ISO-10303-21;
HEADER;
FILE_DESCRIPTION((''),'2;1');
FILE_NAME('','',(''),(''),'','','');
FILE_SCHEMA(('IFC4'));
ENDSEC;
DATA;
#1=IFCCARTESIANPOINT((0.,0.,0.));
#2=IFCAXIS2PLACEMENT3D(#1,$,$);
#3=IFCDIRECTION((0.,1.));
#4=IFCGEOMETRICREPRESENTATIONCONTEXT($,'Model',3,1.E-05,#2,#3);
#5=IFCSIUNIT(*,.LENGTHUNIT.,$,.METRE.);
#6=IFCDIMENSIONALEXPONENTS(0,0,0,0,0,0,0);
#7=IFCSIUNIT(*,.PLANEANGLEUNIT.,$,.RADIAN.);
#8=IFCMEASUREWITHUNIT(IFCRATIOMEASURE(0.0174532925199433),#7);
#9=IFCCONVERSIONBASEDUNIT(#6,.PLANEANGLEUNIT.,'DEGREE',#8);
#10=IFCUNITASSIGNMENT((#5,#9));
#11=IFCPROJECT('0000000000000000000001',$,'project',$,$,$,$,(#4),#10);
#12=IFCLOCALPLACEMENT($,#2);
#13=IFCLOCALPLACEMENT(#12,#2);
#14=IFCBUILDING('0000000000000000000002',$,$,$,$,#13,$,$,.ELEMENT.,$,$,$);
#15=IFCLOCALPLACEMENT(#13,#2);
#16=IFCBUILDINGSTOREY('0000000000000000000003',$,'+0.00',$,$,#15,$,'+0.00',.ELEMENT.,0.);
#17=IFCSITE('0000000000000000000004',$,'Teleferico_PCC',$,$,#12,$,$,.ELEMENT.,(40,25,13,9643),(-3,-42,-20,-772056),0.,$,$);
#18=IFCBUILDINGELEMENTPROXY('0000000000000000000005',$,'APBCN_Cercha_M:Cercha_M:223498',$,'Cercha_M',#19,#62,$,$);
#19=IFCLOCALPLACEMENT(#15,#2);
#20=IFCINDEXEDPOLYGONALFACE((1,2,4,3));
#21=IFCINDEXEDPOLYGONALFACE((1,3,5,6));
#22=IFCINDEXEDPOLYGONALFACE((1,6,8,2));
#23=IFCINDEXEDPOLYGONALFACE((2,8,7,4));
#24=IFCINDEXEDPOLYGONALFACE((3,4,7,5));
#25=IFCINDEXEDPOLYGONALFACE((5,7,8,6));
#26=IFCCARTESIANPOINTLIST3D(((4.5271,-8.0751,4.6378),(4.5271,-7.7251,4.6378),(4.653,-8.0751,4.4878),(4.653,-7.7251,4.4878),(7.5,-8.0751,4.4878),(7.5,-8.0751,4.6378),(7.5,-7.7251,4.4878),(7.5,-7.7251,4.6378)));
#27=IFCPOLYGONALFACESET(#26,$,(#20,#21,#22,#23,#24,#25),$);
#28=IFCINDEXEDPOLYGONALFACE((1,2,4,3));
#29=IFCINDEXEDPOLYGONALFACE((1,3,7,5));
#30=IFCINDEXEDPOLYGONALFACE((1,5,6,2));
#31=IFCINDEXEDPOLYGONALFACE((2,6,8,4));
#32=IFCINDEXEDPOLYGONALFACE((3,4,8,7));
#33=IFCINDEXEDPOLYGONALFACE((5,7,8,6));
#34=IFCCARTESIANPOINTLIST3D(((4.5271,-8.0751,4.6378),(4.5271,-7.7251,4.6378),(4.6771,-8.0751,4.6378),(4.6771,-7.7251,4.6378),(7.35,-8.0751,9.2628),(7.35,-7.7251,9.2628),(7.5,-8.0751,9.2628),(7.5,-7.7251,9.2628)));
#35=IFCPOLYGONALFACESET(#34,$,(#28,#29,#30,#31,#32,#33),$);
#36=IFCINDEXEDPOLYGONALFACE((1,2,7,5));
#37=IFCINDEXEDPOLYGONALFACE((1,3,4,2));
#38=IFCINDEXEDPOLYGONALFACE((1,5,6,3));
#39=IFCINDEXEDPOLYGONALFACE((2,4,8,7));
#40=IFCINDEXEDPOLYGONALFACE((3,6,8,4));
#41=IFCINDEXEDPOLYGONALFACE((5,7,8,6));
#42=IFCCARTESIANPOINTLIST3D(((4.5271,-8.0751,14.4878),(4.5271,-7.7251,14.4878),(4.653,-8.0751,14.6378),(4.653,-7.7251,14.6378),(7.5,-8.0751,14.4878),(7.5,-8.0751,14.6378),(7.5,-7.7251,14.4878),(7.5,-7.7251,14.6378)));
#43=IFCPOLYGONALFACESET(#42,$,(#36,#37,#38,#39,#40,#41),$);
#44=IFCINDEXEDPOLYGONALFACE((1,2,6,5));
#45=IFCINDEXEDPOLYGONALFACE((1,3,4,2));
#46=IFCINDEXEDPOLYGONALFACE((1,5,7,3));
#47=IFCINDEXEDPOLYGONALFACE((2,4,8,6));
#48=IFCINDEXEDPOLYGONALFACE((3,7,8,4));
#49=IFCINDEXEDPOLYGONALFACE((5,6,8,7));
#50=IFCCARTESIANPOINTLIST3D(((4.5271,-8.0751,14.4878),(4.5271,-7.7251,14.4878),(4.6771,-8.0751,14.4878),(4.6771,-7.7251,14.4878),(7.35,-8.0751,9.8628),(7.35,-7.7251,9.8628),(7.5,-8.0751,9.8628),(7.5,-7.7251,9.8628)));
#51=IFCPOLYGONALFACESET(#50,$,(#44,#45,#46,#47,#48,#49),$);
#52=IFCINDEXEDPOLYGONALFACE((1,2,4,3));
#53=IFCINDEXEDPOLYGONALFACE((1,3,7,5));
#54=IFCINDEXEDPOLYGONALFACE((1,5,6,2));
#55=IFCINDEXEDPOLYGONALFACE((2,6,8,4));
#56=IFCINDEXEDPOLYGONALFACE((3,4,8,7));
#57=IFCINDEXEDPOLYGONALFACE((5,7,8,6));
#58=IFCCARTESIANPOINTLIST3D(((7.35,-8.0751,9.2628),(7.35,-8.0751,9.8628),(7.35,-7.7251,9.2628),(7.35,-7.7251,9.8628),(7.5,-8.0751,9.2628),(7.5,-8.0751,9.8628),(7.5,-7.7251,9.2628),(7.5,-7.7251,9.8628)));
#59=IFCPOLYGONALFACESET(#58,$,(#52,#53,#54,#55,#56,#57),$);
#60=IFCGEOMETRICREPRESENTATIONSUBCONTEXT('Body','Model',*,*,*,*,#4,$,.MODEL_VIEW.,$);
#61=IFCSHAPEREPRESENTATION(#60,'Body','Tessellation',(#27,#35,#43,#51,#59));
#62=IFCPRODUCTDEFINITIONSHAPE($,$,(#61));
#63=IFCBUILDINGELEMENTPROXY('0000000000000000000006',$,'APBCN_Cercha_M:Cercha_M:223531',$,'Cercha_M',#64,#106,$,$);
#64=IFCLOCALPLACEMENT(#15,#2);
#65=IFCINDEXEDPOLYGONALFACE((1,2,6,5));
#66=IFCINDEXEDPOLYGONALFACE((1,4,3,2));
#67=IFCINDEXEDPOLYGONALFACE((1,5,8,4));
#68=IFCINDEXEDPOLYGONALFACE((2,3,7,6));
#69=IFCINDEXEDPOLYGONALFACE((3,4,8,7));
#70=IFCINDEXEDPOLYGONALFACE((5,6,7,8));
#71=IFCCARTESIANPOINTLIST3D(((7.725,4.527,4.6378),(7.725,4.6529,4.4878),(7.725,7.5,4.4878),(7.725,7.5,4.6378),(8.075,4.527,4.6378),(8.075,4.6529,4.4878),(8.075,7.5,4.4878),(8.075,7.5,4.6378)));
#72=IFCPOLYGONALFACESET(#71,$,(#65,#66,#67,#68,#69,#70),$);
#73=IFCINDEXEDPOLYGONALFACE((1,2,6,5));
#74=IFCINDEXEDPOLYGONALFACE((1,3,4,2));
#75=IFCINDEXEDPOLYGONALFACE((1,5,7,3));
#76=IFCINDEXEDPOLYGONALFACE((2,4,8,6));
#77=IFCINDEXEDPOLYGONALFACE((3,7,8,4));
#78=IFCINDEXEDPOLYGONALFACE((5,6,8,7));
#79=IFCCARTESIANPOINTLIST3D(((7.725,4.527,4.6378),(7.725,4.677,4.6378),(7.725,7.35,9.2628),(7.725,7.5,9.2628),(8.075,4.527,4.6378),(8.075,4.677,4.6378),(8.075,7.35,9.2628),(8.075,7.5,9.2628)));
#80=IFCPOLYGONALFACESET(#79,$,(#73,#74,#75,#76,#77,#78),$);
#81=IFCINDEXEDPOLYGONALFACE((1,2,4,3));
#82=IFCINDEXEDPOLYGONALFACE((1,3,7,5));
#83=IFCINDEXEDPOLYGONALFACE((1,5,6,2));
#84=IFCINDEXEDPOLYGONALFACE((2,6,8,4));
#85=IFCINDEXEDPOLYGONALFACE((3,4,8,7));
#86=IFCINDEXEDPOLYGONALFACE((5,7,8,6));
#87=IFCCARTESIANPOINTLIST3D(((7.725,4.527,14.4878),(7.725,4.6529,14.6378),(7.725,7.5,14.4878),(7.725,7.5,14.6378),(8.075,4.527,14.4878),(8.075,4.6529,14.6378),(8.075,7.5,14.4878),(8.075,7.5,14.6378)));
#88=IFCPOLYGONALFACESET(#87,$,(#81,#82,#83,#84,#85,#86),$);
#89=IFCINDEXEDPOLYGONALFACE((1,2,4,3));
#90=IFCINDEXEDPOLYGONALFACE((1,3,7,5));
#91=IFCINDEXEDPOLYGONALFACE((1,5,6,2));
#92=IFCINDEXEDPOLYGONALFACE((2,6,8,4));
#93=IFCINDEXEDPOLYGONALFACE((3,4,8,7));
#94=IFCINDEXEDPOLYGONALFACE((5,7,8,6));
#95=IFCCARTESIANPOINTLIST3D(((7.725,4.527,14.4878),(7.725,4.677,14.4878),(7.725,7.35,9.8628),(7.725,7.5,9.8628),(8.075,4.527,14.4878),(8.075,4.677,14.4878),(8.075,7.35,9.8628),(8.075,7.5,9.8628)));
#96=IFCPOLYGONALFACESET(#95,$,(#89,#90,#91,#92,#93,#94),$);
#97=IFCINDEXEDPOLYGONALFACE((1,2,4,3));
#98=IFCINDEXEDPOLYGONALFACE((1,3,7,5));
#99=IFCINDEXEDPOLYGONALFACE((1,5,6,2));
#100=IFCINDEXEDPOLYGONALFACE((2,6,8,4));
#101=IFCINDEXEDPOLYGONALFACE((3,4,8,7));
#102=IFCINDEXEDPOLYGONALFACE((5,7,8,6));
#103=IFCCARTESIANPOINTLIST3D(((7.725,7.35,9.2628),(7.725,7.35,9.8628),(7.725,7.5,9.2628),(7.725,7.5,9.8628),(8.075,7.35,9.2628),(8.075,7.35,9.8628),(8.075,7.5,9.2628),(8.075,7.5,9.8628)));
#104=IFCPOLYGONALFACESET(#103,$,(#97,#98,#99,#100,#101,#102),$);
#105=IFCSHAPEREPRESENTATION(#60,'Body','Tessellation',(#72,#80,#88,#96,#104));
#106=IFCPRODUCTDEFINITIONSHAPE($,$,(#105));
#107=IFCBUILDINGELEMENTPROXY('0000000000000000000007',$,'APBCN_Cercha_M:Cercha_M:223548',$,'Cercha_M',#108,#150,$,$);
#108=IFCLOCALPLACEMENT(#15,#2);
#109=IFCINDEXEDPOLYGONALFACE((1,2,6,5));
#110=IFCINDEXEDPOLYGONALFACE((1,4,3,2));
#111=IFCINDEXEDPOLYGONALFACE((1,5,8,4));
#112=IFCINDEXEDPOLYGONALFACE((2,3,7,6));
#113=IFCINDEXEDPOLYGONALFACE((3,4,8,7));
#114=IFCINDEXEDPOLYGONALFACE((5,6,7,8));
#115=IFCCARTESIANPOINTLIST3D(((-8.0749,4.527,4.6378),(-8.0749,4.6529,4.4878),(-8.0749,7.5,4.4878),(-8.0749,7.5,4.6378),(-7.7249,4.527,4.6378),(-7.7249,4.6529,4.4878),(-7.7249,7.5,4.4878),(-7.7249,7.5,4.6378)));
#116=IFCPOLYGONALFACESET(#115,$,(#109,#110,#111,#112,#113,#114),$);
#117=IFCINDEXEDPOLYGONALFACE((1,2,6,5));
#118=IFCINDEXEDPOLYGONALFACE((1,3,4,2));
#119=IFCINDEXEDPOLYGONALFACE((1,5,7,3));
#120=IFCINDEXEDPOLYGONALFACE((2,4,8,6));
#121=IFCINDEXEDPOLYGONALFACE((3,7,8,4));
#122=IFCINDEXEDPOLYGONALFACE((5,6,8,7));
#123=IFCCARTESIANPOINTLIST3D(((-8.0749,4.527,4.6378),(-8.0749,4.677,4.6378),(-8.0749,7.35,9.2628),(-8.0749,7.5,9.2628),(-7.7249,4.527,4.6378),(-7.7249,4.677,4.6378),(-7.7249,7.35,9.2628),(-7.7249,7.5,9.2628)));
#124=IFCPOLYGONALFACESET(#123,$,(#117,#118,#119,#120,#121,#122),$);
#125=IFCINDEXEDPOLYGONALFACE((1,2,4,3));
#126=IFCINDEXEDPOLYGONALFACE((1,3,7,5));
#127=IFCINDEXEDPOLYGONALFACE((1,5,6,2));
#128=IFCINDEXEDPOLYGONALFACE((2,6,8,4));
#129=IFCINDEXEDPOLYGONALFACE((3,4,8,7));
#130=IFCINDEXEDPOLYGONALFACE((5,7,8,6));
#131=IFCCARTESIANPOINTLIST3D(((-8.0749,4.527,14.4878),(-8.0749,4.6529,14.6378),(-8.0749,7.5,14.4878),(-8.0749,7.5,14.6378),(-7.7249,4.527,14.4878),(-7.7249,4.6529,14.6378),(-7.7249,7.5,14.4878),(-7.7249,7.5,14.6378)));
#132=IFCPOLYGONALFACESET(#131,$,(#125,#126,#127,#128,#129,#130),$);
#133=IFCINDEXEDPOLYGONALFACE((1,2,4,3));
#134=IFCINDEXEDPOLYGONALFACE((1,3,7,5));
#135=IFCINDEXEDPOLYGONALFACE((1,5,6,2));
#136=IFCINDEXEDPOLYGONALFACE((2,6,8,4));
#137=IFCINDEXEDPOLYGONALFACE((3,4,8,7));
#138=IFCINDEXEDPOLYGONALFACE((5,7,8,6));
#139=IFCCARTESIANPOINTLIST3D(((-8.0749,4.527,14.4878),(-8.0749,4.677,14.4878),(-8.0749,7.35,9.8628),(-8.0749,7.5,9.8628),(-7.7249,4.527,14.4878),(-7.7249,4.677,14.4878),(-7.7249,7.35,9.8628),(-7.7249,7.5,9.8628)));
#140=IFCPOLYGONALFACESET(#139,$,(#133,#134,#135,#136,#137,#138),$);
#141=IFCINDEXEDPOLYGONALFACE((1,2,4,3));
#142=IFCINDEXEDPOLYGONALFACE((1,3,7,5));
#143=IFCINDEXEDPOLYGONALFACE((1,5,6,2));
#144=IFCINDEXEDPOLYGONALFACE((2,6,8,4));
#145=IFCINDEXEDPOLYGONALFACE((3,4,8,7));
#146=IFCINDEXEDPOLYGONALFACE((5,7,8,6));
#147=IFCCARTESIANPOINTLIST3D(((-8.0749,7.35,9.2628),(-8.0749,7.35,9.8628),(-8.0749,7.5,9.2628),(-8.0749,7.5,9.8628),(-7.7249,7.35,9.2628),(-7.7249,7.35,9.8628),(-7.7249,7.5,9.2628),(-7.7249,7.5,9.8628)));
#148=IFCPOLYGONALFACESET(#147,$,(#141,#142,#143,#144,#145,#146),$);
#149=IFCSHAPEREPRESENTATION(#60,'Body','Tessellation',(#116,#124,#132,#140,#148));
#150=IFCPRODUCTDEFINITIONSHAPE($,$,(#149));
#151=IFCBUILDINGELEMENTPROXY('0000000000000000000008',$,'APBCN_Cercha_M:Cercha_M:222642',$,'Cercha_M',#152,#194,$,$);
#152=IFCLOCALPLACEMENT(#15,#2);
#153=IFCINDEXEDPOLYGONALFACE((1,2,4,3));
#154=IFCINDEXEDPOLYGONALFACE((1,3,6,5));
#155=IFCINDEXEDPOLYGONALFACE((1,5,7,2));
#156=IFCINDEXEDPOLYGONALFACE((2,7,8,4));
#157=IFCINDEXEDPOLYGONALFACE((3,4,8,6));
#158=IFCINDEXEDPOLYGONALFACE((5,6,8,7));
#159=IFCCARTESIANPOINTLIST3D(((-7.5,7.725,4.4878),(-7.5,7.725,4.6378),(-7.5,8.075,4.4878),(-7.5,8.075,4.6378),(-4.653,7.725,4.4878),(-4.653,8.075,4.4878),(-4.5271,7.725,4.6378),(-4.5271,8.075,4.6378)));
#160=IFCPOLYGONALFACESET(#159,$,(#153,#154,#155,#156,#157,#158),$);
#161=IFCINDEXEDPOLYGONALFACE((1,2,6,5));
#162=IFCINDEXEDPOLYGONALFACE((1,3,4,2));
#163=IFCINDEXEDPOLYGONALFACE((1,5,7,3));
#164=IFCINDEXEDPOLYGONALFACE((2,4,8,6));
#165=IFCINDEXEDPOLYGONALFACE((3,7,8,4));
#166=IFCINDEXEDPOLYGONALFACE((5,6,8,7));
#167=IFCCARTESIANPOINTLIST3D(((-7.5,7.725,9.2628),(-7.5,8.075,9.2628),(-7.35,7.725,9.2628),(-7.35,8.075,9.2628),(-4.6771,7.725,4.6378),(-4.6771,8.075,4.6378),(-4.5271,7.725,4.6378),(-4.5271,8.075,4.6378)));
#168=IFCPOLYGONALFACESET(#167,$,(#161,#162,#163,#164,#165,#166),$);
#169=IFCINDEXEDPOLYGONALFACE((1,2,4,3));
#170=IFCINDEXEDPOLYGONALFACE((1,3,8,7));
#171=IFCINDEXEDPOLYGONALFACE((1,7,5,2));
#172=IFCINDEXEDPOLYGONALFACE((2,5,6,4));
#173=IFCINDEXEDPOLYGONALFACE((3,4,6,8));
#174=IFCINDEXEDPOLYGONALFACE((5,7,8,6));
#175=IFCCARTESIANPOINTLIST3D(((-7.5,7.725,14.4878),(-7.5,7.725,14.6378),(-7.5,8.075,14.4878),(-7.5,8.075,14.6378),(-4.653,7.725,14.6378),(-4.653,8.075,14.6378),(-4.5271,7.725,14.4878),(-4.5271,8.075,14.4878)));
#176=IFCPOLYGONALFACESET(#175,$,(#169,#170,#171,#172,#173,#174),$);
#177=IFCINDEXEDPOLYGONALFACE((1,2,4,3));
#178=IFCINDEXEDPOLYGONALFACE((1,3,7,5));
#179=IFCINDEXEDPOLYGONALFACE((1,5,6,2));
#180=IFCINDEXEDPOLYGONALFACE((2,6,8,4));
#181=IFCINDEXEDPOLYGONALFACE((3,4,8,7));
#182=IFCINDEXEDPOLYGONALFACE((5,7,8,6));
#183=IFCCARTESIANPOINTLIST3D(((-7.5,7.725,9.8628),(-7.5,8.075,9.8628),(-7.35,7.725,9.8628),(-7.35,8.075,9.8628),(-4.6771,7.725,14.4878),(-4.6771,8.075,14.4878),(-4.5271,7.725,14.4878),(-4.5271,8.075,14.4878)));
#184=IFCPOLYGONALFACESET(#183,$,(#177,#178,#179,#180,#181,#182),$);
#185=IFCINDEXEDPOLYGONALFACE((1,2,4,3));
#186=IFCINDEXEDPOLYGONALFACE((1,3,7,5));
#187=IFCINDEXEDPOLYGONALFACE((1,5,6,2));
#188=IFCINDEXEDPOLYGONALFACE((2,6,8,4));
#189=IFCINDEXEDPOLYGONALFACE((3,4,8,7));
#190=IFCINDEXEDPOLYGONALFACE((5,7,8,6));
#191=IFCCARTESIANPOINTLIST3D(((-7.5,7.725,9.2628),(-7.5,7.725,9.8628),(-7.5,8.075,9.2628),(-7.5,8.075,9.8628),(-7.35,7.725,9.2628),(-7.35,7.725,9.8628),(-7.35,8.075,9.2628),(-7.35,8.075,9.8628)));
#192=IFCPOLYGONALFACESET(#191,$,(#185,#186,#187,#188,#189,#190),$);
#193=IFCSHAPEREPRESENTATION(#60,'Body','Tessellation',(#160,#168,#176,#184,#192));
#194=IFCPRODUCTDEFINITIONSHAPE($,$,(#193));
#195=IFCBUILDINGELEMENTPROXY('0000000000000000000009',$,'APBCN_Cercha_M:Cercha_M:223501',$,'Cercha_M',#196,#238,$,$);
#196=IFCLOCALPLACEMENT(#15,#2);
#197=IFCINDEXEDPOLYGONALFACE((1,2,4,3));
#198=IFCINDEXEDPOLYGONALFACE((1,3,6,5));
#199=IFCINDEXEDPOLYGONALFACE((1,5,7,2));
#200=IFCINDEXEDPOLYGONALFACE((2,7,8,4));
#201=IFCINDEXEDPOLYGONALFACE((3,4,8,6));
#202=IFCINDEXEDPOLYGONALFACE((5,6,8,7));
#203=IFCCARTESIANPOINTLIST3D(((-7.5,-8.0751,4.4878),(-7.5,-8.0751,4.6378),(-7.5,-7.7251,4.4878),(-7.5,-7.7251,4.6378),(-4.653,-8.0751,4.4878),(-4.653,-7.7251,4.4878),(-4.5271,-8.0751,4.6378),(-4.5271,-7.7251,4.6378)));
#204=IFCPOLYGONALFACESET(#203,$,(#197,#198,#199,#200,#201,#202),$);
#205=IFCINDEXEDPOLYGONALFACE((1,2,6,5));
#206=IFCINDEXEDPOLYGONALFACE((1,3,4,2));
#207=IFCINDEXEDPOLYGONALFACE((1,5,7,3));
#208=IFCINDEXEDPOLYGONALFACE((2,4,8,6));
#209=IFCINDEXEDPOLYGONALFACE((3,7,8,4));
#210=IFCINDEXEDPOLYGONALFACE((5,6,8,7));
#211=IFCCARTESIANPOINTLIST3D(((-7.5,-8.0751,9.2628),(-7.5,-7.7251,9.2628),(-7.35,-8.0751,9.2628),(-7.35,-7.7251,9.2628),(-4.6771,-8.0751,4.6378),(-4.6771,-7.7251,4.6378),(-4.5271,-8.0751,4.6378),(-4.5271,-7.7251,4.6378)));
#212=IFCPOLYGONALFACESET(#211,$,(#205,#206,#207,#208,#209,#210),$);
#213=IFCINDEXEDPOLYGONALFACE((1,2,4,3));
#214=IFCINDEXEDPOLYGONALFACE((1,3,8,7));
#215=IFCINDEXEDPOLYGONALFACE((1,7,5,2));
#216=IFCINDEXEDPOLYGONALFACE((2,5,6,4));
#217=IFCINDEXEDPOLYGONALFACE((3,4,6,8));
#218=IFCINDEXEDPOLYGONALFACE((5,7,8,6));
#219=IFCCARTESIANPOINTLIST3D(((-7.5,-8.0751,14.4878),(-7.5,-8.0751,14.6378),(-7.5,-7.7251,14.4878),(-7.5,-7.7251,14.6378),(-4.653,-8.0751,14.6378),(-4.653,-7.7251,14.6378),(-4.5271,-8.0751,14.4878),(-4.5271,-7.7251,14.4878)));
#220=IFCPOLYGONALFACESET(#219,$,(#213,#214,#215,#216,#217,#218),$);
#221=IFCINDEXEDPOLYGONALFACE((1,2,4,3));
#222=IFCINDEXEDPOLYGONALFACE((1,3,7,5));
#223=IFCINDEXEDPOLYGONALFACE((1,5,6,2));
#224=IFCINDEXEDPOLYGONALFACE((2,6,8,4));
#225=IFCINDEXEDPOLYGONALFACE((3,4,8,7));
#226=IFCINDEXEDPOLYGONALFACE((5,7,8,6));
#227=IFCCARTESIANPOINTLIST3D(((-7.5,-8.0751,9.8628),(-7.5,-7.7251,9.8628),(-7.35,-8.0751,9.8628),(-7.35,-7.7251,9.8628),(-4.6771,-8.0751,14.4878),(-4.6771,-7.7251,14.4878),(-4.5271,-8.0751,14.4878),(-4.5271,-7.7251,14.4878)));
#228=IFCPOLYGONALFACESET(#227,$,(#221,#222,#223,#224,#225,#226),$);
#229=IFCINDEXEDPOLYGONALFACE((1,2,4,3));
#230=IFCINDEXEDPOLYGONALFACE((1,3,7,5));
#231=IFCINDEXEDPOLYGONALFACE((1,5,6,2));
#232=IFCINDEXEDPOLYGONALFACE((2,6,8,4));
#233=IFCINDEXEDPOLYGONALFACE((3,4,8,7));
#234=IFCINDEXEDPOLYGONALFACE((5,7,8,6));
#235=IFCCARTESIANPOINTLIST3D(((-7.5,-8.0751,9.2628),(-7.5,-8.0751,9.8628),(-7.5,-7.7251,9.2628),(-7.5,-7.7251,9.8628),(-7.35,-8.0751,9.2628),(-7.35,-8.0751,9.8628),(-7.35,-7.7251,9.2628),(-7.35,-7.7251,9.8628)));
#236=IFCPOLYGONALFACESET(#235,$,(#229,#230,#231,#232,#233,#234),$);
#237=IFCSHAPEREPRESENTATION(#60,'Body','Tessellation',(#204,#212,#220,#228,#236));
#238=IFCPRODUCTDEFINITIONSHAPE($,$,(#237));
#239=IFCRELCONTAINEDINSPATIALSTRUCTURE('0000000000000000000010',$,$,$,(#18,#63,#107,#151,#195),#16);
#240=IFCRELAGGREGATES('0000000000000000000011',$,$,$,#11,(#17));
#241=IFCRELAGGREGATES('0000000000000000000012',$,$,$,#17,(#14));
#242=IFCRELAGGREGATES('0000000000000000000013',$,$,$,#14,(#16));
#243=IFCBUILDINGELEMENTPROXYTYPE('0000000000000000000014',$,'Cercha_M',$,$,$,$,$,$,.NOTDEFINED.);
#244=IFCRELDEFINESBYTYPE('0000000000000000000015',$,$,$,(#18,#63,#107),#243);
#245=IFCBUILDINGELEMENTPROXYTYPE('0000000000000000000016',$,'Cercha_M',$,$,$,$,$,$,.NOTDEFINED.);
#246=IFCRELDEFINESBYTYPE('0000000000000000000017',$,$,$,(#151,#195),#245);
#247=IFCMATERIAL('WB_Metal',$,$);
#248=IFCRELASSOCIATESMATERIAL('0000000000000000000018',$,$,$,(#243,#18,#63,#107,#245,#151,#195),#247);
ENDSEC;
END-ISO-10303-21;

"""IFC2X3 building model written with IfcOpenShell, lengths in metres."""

from ifc_helpers import new_model, entity, si_unit, converted_unit, direction, frame, origin, origin_2d_with_axis, place, context, subcontext, project, spatial, polyline, rectangle, outline, extrude, source, transform, mapped, material, type_object, type_shapes, element, save


model = new_model("IFC2X3")

# Units and contexts
model_context = context("Model", 3, precision=1e-05, world=origin(), true_north=direction((0.0, 1.0)))
body_context = subcontext(model_context, "Body", "Model", "MODEL_VIEW")
ifc_project = project(units=[si_unit("LENGTHUNIT", "METRE"), converted_unit("PLANEANGLEUNIT", "DEGREE", entity("IfcRatioMeasure", 0.0174532925199433), si_unit("PLANEANGLEUNIT", "RADIAN"), dimensions=[0, 0, 0, 0, 0, 0, 0])], contexts=[model_context])

# Site, building, storey
site_placement = place(None, origin())
site = spatial("IfcSite", under=ifc_project, at=site_placement, Name="Teleferico_PCC", CompositionType="ELEMENT", RefLatitude=(40, 25, 13, 9643), RefLongitude=(-3, -42, -20, -772056), RefElevation=0.0)
building_placement = place(site_placement, origin())
building = spatial("IfcBuilding", under=site, at=building_placement, CompositionType="ELEMENT")
storey_placement = place(building_placement, origin())
storey = spatial("IfcBuildingStorey", under=building, at=storey_placement, Name="+0.00", LongName="+0.00", CompositionType="ELEMENT", Elevation=0.0)

# Shared definitions
ifc_material = material(Name="WB_Metal")

# Building element proxies
building_element_proxy_type_1 = type_object("IfcBuildingElementProxyType", Name="Cercha_M", PredefinedType="NOTDEFINED", material=ifc_material)
shared_shape_1 = source(origin(), body_context, "Body", "SweptSolid", [
    extrude(outline(polyline([(-1.455, -0.075), (1.3921, -0.075), (1.5179, 0.075), (-1.455, 0.075), (-1.455, -0.075)])), frame((-1.455, -0.175, -5.0), z_axis=(0.0, 1.0, 0.0), x_axis=(-1.0, 0.0, 0.0)), (0.0, 0.0, 1.0), 0.35),
    extrude(outline(polyline([(1.3365, -2.3125), (1.4865, -2.3125), (-1.3365, 2.3125), (-1.4865, 2.3125), (1.3365, -2.3125)])), frame((-1.4865, -0.175, -2.6125), z_axis=(0.0, 1.0, 0.0), x_axis=(1.0, 0.0, 0.0)), (0.0, 0.0, 1.0), 0.35),
    extrude(outline(polyline([(-1.455, -0.075), (1.5179, -0.075), (1.3921, 0.075), (-1.455, 0.075), (-1.455, -0.075)])), frame((-1.455, -0.175, 5.0), z_axis=(0.0, 1.0, 0.0), x_axis=(-1.0, 0.0, 0.0)), (0.0, 0.0, 1.0), 0.35),
    extrude(outline(polyline([(-2.6701, -0.064), (2.7483, -0.064), (2.6701, 0.064), (-2.7483, 0.064), (-2.6701, -0.064)])), frame((-1.4865, -0.175, 2.6125), z_axis=(0.0, 1.0, 0.0), x_axis=(-0.520985, 0.0, 0.853566)), (0.0, 0.0, 1.0), 0.35),
    extrude(rectangle(XDim=0.35, YDim=0.15, at=origin_2d_with_axis()), frame((-0.075, 0.0, -0.3), z_axis=(0.0, 0.0, 1.0), x_axis=(0.0, 1.0, 0.0)), (0.0, 0.0, 1.0), 0.6),
])
type_shapes(building_element_proxy_type_1, [shared_shape_1])
for number, where, name in (
    (1, (7.5, -7.9001, 9.5628), "APBCN_Cercha_M:Cercha_M:223498"),
):
    element("IfcBuildingElementProxy", number, at=place(storey_placement, frame(where)), inside=storey, type_object=building_element_proxy_type_1, material=ifc_material, Name=name, ObjectType="Cercha_M", context=body_context, shape_type="MappedRepresentation", body=[
        mapped(shared_shape_1, transform((0.0, 0.0, 0.0), scale=1.0)),
    ])
for number, where, z_axis, x_axis, name in (
    (2, (7.9, 7.5, 9.5628), (0.0, 0.0, 1.0), (0.0, 1.0, 0.0), "APBCN_Cercha_M:Cercha_M:223531"),
    (3, (-7.8999, 7.5, 9.5628), (0.0, 0.0, 1.0), (0.0, 1.0, 0.0), "APBCN_Cercha_M:Cercha_M:223548"),
):
    element("IfcBuildingElementProxy", number, at=place(storey_placement, frame(where, z_axis=z_axis, x_axis=x_axis)), inside=storey, type_object=building_element_proxy_type_1, material=ifc_material, Name=name, ObjectType="Cercha_M", context=body_context, shape_type="MappedRepresentation", body=[
        mapped(shared_shape_1, transform((0.0, 0.0, 0.0), scale=1.0)),
    ])
building_element_proxy_type_2 = type_object("IfcBuildingElementProxyType", Name="Cercha_M", PredefinedType="NOTDEFINED", material=ifc_material)
shared_shape_2 = source(origin(), body_context, "Body", "SweptSolid", [
    extrude(outline(polyline([(-0.075, -1.455), (0.075, -1.455), (0.075, 1.3921), (-0.075, 1.5179), (-0.075, -1.455)])), frame((-1.455, -0.175, -5.0), z_axis=(0.0, 1.0, 0.0), x_axis=(0.0, 0.0, -1.0)), (0.0, 0.0, 1.0), 0.35),
    extrude(outline(polyline([(1.3365, -2.3125), (1.4865, -2.3125), (-1.3365, 2.3125), (-1.4865, 2.3125), (1.3365, -2.3125)])), frame((-1.4865, -0.175, -2.6125), z_axis=(0.0, 1.0, 0.0), x_axis=(1.0, 0.0, 0.0)), (0.0, 0.0, 1.0), 0.35),
    extrude(outline(polyline([(-0.075, -1.455), (0.075, -1.455), (0.075, 1.5179), (-0.075, 1.3921), (-0.075, -1.455)])), frame((-1.455, -0.175, 5.0), z_axis=(0.0, 1.0, 0.0), x_axis=(0.0, 0.0, -1.0)), (0.0, 0.0, 1.0), 0.35),
    extrude(outline(polyline([(-2.6701, -0.064), (2.7483, -0.064), (2.6701, 0.064), (-2.7483, 0.064), (-2.6701, -0.064)])), frame((-1.4865, -0.175, 2.6125), z_axis=(0.0, 1.0, 0.0), x_axis=(-0.520985, 0.0, 0.853566)), (0.0, 0.0, 1.0), 0.35),
    extrude(rectangle(XDim=0.15, YDim=0.35, at=origin_2d_with_axis()), frame((-0.075, 0.0, -0.3), z_axis=(0.0, 0.0, 1.0), x_axis=(-1.0, 0.0, 0.0)), (0.0, 0.0, 1.0), 0.6),
])
type_shapes(building_element_proxy_type_2, [shared_shape_2])
for number, where, z_axis, x_axis, name in (
    (4, (-7.5, 7.9, 9.5628), (0.0, 0.0, 1.0), (-1.0, 0.0, 0.0), "APBCN_Cercha_M:Cercha_M:222642"),
    (5, (-7.5, -7.9001, 9.5628), (0.0, 0.0, 1.0), (-1.0, 0.0, 0.0), "APBCN_Cercha_M:Cercha_M:223501"),
):
    element("IfcBuildingElementProxy", number, at=place(storey_placement, frame(where, z_axis=z_axis, x_axis=x_axis)), inside=storey, type_object=building_element_proxy_type_2, material=ifc_material, Name=name, ObjectType="Cercha_M", context=body_context, shape_type="MappedRepresentation", body=[
        mapped(shared_shape_2, transform((0.0, 0.0, 0.0), scale=1.0)),
    ])

save(model, "model.ifc")
